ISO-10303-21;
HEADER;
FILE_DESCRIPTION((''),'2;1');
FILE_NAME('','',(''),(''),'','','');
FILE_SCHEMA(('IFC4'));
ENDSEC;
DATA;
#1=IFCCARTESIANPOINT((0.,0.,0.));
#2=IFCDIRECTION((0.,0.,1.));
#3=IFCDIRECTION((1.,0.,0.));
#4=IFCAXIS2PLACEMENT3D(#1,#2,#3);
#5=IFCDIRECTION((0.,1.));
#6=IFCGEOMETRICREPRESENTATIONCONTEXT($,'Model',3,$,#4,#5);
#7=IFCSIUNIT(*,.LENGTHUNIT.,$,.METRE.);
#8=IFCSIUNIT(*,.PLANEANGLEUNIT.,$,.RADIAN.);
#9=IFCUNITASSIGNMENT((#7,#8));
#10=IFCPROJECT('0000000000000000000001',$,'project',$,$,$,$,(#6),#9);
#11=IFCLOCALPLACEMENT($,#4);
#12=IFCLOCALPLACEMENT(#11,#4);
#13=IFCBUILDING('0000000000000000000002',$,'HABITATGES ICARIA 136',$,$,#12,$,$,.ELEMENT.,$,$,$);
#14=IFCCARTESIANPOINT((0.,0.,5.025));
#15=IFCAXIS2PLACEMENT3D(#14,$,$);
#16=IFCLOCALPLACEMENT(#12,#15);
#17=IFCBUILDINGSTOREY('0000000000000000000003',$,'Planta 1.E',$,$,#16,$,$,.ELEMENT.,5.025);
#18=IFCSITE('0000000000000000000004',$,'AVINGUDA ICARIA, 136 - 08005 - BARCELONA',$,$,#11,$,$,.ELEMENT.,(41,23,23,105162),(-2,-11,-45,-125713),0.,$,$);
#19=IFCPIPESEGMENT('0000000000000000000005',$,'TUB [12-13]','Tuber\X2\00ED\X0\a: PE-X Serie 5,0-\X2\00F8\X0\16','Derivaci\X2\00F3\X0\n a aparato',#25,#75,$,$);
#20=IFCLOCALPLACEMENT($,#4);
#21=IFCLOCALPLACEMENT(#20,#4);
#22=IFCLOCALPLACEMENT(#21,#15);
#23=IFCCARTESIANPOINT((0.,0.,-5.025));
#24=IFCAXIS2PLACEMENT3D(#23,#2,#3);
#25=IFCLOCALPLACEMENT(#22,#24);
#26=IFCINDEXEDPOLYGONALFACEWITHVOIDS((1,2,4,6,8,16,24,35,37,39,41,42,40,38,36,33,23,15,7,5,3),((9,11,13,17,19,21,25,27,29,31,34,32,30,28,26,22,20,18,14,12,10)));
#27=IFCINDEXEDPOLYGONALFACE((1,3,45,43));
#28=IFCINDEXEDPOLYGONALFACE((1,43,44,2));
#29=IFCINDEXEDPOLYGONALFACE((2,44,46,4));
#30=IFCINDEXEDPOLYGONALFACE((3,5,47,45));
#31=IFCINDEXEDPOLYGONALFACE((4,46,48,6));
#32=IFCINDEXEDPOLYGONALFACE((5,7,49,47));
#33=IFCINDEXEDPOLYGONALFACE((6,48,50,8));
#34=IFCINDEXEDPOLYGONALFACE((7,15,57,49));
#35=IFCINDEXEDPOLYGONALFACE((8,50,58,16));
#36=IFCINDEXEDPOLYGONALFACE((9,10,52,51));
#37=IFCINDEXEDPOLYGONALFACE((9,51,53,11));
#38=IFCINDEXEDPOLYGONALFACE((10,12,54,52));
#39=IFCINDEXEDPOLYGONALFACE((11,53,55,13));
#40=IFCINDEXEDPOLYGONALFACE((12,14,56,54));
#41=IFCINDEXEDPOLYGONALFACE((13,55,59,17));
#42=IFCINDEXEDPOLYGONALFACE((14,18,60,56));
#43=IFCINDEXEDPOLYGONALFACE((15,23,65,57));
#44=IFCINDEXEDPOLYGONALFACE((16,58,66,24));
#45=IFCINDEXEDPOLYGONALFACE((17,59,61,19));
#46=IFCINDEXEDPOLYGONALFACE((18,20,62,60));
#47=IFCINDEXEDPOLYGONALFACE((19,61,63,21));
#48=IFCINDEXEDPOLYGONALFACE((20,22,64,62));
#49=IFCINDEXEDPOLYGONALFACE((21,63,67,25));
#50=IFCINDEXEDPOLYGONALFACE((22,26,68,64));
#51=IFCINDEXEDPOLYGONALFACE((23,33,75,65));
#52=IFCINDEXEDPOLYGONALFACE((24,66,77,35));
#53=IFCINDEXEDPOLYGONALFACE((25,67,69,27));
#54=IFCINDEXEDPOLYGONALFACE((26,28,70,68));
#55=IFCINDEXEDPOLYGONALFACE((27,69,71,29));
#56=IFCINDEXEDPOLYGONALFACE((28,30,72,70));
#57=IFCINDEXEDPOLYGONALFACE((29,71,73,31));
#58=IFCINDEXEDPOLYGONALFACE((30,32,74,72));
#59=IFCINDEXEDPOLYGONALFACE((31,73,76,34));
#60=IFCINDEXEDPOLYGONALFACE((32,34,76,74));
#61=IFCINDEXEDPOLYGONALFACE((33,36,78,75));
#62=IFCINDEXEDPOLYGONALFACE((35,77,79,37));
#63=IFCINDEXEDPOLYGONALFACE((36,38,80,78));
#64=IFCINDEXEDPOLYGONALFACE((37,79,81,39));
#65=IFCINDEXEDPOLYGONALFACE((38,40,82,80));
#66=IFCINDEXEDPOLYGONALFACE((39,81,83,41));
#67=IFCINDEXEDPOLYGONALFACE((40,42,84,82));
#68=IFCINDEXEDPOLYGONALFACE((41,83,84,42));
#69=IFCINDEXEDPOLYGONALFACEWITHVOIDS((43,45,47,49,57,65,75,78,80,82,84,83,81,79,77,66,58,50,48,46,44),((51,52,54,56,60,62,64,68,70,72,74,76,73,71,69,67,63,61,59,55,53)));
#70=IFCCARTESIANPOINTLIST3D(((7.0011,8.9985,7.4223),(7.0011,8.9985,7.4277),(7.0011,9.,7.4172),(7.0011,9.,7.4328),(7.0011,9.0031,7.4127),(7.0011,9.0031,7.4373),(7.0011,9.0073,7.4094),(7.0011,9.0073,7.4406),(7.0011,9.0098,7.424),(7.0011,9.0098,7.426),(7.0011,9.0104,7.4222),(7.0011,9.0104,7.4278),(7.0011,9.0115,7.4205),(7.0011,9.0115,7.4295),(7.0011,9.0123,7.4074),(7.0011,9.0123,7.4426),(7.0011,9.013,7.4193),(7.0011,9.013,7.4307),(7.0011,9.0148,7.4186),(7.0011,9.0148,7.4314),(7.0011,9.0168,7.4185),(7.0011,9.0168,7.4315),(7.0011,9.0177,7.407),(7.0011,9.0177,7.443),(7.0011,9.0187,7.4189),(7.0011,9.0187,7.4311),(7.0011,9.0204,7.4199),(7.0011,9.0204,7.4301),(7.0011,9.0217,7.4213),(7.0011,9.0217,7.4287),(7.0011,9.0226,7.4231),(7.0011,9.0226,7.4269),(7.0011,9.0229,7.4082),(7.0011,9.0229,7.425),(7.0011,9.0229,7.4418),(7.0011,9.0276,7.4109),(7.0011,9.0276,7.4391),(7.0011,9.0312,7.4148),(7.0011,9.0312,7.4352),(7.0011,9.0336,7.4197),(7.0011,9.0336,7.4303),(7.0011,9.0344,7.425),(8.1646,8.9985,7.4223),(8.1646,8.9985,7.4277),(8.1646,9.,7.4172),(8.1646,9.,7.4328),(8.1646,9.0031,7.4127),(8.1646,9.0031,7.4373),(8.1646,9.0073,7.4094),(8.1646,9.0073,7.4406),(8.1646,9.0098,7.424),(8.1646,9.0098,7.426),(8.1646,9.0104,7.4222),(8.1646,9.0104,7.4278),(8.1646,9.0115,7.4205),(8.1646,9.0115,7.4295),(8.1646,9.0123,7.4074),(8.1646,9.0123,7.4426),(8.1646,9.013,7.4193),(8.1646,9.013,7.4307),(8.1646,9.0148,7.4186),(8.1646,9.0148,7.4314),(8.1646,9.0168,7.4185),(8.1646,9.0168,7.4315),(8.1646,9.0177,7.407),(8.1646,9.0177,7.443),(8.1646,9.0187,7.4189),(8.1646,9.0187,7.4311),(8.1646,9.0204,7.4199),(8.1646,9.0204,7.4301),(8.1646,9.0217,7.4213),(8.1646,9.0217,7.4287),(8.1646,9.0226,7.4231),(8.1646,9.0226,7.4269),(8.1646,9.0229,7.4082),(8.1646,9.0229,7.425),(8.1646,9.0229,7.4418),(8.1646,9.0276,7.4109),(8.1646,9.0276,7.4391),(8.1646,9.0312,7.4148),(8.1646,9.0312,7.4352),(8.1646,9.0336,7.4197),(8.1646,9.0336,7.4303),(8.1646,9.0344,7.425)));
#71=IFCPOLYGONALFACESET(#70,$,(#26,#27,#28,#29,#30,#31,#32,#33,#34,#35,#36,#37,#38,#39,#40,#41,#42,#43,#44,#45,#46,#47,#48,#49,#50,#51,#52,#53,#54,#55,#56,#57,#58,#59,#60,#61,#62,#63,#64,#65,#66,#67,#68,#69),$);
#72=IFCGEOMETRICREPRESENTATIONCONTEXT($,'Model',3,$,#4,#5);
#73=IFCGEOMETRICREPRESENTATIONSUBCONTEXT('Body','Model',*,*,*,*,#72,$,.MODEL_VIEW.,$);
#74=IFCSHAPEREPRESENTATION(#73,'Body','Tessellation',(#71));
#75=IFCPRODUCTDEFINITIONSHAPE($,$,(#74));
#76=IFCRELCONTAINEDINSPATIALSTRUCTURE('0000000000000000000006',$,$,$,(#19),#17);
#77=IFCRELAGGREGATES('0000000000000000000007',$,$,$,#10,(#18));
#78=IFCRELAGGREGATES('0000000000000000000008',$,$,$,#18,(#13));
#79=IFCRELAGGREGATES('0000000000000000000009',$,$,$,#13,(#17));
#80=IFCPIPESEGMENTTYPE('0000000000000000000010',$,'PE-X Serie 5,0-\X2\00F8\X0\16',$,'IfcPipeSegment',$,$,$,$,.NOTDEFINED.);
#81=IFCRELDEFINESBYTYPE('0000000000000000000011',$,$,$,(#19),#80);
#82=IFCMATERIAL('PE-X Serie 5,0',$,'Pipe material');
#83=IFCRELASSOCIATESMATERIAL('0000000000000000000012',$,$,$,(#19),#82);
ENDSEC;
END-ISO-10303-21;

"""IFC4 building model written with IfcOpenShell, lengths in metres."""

from ifc_helpers import new_model, si_unit, direction, frame, origin_with_axes, origin_2d_with_axis, place, context, subcontext, project, spatial, hollow_circle, extrude, material, type_object, element, save


model = new_model("IFC4")

# Units and contexts
model_context_1 = context("Model", 3, world=origin_with_axes(), true_north=direction((0.0, 1.0)))
model_context_2 = context("Model", 3, world=origin_with_axes(), true_north=direction((0.0, 1.0)))
body_context_1 = subcontext(model_context_2, "Body", "Model", "MODEL_VIEW")
ifc_project = project(units=[si_unit("LENGTHUNIT", "METRE"), si_unit("PLANEANGLEUNIT", "RADIAN")], contexts=[model_context_1])

# Site, building, storey
site_placement = place(None, origin_with_axes())
site = spatial("IfcSite", under=ifc_project, at=site_placement, Name="AVINGUDA ICARIA, 136 - 08005 - BARCELONA", CompositionType="ELEMENT", RefLatitude=(41, 23, 23, 105162), RefLongitude=(-2, -11, -45, -125713), RefElevation=0.0)
building_placement = place(site_placement, origin_with_axes())
building = spatial("IfcBuilding", under=site, at=building_placement, Name="HABITATGES ICARIA 136", CompositionType="ELEMENT")
storey_placement = place(building_placement, frame((0.0, 0.0, 5.025)))
storey = spatial("IfcBuildingStorey", under=building, at=storey_placement, Name="Planta 1.E", CompositionType="ELEMENT", Elevation=5.025)

# Shared definitions
ifc_material_1 = material(Name="PE-X Serie 5,0", Category="Pipe material")
placement_1 = place(None, origin_with_axes())
placement_2 = place(placement_1, origin_with_axes())
placement_3 = place(placement_2, frame((0.0, 0.0, 5.025)))

# Pipe segment
pipe_segment_type_1 = type_object("IfcPipeSegmentType", Name="PE-X Serie 5,0-ø16", ApplicableOccurrence="IfcPipeSegment", PredefinedType="NOTDEFINED")
pipe_segment_1_placement = place(placement_3, frame((0.0, 0.0, -5.025), z_axis=(0.0, 0.0, 1.0), x_axis=(1.0, 0.0, 0.0)))
element("IfcPipeSegment", 1, at=pipe_segment_1_placement, inside=storey, type_object=pipe_segment_type_1, material=ifc_material_1, Name="TUB [12-13]", Description="Tubería: PE-X Serie 5,0-ø16", ObjectType="Derivación a aparato", context=body_context_1, shape_type="SweptSolid", body=[
    extrude(hollow_circle(Radius=0.0181, WallThickness=0.0115, at=origin_2d_with_axis()), frame((7.0011, 9.0163, 7.425), z_axis=(1.0, 0.0, 0.0), x_axis=(0.0, 1.0, 0.0)), (0.0, 0.0, 1.0), 1.1635),
])

save(model, "model.ifc")
